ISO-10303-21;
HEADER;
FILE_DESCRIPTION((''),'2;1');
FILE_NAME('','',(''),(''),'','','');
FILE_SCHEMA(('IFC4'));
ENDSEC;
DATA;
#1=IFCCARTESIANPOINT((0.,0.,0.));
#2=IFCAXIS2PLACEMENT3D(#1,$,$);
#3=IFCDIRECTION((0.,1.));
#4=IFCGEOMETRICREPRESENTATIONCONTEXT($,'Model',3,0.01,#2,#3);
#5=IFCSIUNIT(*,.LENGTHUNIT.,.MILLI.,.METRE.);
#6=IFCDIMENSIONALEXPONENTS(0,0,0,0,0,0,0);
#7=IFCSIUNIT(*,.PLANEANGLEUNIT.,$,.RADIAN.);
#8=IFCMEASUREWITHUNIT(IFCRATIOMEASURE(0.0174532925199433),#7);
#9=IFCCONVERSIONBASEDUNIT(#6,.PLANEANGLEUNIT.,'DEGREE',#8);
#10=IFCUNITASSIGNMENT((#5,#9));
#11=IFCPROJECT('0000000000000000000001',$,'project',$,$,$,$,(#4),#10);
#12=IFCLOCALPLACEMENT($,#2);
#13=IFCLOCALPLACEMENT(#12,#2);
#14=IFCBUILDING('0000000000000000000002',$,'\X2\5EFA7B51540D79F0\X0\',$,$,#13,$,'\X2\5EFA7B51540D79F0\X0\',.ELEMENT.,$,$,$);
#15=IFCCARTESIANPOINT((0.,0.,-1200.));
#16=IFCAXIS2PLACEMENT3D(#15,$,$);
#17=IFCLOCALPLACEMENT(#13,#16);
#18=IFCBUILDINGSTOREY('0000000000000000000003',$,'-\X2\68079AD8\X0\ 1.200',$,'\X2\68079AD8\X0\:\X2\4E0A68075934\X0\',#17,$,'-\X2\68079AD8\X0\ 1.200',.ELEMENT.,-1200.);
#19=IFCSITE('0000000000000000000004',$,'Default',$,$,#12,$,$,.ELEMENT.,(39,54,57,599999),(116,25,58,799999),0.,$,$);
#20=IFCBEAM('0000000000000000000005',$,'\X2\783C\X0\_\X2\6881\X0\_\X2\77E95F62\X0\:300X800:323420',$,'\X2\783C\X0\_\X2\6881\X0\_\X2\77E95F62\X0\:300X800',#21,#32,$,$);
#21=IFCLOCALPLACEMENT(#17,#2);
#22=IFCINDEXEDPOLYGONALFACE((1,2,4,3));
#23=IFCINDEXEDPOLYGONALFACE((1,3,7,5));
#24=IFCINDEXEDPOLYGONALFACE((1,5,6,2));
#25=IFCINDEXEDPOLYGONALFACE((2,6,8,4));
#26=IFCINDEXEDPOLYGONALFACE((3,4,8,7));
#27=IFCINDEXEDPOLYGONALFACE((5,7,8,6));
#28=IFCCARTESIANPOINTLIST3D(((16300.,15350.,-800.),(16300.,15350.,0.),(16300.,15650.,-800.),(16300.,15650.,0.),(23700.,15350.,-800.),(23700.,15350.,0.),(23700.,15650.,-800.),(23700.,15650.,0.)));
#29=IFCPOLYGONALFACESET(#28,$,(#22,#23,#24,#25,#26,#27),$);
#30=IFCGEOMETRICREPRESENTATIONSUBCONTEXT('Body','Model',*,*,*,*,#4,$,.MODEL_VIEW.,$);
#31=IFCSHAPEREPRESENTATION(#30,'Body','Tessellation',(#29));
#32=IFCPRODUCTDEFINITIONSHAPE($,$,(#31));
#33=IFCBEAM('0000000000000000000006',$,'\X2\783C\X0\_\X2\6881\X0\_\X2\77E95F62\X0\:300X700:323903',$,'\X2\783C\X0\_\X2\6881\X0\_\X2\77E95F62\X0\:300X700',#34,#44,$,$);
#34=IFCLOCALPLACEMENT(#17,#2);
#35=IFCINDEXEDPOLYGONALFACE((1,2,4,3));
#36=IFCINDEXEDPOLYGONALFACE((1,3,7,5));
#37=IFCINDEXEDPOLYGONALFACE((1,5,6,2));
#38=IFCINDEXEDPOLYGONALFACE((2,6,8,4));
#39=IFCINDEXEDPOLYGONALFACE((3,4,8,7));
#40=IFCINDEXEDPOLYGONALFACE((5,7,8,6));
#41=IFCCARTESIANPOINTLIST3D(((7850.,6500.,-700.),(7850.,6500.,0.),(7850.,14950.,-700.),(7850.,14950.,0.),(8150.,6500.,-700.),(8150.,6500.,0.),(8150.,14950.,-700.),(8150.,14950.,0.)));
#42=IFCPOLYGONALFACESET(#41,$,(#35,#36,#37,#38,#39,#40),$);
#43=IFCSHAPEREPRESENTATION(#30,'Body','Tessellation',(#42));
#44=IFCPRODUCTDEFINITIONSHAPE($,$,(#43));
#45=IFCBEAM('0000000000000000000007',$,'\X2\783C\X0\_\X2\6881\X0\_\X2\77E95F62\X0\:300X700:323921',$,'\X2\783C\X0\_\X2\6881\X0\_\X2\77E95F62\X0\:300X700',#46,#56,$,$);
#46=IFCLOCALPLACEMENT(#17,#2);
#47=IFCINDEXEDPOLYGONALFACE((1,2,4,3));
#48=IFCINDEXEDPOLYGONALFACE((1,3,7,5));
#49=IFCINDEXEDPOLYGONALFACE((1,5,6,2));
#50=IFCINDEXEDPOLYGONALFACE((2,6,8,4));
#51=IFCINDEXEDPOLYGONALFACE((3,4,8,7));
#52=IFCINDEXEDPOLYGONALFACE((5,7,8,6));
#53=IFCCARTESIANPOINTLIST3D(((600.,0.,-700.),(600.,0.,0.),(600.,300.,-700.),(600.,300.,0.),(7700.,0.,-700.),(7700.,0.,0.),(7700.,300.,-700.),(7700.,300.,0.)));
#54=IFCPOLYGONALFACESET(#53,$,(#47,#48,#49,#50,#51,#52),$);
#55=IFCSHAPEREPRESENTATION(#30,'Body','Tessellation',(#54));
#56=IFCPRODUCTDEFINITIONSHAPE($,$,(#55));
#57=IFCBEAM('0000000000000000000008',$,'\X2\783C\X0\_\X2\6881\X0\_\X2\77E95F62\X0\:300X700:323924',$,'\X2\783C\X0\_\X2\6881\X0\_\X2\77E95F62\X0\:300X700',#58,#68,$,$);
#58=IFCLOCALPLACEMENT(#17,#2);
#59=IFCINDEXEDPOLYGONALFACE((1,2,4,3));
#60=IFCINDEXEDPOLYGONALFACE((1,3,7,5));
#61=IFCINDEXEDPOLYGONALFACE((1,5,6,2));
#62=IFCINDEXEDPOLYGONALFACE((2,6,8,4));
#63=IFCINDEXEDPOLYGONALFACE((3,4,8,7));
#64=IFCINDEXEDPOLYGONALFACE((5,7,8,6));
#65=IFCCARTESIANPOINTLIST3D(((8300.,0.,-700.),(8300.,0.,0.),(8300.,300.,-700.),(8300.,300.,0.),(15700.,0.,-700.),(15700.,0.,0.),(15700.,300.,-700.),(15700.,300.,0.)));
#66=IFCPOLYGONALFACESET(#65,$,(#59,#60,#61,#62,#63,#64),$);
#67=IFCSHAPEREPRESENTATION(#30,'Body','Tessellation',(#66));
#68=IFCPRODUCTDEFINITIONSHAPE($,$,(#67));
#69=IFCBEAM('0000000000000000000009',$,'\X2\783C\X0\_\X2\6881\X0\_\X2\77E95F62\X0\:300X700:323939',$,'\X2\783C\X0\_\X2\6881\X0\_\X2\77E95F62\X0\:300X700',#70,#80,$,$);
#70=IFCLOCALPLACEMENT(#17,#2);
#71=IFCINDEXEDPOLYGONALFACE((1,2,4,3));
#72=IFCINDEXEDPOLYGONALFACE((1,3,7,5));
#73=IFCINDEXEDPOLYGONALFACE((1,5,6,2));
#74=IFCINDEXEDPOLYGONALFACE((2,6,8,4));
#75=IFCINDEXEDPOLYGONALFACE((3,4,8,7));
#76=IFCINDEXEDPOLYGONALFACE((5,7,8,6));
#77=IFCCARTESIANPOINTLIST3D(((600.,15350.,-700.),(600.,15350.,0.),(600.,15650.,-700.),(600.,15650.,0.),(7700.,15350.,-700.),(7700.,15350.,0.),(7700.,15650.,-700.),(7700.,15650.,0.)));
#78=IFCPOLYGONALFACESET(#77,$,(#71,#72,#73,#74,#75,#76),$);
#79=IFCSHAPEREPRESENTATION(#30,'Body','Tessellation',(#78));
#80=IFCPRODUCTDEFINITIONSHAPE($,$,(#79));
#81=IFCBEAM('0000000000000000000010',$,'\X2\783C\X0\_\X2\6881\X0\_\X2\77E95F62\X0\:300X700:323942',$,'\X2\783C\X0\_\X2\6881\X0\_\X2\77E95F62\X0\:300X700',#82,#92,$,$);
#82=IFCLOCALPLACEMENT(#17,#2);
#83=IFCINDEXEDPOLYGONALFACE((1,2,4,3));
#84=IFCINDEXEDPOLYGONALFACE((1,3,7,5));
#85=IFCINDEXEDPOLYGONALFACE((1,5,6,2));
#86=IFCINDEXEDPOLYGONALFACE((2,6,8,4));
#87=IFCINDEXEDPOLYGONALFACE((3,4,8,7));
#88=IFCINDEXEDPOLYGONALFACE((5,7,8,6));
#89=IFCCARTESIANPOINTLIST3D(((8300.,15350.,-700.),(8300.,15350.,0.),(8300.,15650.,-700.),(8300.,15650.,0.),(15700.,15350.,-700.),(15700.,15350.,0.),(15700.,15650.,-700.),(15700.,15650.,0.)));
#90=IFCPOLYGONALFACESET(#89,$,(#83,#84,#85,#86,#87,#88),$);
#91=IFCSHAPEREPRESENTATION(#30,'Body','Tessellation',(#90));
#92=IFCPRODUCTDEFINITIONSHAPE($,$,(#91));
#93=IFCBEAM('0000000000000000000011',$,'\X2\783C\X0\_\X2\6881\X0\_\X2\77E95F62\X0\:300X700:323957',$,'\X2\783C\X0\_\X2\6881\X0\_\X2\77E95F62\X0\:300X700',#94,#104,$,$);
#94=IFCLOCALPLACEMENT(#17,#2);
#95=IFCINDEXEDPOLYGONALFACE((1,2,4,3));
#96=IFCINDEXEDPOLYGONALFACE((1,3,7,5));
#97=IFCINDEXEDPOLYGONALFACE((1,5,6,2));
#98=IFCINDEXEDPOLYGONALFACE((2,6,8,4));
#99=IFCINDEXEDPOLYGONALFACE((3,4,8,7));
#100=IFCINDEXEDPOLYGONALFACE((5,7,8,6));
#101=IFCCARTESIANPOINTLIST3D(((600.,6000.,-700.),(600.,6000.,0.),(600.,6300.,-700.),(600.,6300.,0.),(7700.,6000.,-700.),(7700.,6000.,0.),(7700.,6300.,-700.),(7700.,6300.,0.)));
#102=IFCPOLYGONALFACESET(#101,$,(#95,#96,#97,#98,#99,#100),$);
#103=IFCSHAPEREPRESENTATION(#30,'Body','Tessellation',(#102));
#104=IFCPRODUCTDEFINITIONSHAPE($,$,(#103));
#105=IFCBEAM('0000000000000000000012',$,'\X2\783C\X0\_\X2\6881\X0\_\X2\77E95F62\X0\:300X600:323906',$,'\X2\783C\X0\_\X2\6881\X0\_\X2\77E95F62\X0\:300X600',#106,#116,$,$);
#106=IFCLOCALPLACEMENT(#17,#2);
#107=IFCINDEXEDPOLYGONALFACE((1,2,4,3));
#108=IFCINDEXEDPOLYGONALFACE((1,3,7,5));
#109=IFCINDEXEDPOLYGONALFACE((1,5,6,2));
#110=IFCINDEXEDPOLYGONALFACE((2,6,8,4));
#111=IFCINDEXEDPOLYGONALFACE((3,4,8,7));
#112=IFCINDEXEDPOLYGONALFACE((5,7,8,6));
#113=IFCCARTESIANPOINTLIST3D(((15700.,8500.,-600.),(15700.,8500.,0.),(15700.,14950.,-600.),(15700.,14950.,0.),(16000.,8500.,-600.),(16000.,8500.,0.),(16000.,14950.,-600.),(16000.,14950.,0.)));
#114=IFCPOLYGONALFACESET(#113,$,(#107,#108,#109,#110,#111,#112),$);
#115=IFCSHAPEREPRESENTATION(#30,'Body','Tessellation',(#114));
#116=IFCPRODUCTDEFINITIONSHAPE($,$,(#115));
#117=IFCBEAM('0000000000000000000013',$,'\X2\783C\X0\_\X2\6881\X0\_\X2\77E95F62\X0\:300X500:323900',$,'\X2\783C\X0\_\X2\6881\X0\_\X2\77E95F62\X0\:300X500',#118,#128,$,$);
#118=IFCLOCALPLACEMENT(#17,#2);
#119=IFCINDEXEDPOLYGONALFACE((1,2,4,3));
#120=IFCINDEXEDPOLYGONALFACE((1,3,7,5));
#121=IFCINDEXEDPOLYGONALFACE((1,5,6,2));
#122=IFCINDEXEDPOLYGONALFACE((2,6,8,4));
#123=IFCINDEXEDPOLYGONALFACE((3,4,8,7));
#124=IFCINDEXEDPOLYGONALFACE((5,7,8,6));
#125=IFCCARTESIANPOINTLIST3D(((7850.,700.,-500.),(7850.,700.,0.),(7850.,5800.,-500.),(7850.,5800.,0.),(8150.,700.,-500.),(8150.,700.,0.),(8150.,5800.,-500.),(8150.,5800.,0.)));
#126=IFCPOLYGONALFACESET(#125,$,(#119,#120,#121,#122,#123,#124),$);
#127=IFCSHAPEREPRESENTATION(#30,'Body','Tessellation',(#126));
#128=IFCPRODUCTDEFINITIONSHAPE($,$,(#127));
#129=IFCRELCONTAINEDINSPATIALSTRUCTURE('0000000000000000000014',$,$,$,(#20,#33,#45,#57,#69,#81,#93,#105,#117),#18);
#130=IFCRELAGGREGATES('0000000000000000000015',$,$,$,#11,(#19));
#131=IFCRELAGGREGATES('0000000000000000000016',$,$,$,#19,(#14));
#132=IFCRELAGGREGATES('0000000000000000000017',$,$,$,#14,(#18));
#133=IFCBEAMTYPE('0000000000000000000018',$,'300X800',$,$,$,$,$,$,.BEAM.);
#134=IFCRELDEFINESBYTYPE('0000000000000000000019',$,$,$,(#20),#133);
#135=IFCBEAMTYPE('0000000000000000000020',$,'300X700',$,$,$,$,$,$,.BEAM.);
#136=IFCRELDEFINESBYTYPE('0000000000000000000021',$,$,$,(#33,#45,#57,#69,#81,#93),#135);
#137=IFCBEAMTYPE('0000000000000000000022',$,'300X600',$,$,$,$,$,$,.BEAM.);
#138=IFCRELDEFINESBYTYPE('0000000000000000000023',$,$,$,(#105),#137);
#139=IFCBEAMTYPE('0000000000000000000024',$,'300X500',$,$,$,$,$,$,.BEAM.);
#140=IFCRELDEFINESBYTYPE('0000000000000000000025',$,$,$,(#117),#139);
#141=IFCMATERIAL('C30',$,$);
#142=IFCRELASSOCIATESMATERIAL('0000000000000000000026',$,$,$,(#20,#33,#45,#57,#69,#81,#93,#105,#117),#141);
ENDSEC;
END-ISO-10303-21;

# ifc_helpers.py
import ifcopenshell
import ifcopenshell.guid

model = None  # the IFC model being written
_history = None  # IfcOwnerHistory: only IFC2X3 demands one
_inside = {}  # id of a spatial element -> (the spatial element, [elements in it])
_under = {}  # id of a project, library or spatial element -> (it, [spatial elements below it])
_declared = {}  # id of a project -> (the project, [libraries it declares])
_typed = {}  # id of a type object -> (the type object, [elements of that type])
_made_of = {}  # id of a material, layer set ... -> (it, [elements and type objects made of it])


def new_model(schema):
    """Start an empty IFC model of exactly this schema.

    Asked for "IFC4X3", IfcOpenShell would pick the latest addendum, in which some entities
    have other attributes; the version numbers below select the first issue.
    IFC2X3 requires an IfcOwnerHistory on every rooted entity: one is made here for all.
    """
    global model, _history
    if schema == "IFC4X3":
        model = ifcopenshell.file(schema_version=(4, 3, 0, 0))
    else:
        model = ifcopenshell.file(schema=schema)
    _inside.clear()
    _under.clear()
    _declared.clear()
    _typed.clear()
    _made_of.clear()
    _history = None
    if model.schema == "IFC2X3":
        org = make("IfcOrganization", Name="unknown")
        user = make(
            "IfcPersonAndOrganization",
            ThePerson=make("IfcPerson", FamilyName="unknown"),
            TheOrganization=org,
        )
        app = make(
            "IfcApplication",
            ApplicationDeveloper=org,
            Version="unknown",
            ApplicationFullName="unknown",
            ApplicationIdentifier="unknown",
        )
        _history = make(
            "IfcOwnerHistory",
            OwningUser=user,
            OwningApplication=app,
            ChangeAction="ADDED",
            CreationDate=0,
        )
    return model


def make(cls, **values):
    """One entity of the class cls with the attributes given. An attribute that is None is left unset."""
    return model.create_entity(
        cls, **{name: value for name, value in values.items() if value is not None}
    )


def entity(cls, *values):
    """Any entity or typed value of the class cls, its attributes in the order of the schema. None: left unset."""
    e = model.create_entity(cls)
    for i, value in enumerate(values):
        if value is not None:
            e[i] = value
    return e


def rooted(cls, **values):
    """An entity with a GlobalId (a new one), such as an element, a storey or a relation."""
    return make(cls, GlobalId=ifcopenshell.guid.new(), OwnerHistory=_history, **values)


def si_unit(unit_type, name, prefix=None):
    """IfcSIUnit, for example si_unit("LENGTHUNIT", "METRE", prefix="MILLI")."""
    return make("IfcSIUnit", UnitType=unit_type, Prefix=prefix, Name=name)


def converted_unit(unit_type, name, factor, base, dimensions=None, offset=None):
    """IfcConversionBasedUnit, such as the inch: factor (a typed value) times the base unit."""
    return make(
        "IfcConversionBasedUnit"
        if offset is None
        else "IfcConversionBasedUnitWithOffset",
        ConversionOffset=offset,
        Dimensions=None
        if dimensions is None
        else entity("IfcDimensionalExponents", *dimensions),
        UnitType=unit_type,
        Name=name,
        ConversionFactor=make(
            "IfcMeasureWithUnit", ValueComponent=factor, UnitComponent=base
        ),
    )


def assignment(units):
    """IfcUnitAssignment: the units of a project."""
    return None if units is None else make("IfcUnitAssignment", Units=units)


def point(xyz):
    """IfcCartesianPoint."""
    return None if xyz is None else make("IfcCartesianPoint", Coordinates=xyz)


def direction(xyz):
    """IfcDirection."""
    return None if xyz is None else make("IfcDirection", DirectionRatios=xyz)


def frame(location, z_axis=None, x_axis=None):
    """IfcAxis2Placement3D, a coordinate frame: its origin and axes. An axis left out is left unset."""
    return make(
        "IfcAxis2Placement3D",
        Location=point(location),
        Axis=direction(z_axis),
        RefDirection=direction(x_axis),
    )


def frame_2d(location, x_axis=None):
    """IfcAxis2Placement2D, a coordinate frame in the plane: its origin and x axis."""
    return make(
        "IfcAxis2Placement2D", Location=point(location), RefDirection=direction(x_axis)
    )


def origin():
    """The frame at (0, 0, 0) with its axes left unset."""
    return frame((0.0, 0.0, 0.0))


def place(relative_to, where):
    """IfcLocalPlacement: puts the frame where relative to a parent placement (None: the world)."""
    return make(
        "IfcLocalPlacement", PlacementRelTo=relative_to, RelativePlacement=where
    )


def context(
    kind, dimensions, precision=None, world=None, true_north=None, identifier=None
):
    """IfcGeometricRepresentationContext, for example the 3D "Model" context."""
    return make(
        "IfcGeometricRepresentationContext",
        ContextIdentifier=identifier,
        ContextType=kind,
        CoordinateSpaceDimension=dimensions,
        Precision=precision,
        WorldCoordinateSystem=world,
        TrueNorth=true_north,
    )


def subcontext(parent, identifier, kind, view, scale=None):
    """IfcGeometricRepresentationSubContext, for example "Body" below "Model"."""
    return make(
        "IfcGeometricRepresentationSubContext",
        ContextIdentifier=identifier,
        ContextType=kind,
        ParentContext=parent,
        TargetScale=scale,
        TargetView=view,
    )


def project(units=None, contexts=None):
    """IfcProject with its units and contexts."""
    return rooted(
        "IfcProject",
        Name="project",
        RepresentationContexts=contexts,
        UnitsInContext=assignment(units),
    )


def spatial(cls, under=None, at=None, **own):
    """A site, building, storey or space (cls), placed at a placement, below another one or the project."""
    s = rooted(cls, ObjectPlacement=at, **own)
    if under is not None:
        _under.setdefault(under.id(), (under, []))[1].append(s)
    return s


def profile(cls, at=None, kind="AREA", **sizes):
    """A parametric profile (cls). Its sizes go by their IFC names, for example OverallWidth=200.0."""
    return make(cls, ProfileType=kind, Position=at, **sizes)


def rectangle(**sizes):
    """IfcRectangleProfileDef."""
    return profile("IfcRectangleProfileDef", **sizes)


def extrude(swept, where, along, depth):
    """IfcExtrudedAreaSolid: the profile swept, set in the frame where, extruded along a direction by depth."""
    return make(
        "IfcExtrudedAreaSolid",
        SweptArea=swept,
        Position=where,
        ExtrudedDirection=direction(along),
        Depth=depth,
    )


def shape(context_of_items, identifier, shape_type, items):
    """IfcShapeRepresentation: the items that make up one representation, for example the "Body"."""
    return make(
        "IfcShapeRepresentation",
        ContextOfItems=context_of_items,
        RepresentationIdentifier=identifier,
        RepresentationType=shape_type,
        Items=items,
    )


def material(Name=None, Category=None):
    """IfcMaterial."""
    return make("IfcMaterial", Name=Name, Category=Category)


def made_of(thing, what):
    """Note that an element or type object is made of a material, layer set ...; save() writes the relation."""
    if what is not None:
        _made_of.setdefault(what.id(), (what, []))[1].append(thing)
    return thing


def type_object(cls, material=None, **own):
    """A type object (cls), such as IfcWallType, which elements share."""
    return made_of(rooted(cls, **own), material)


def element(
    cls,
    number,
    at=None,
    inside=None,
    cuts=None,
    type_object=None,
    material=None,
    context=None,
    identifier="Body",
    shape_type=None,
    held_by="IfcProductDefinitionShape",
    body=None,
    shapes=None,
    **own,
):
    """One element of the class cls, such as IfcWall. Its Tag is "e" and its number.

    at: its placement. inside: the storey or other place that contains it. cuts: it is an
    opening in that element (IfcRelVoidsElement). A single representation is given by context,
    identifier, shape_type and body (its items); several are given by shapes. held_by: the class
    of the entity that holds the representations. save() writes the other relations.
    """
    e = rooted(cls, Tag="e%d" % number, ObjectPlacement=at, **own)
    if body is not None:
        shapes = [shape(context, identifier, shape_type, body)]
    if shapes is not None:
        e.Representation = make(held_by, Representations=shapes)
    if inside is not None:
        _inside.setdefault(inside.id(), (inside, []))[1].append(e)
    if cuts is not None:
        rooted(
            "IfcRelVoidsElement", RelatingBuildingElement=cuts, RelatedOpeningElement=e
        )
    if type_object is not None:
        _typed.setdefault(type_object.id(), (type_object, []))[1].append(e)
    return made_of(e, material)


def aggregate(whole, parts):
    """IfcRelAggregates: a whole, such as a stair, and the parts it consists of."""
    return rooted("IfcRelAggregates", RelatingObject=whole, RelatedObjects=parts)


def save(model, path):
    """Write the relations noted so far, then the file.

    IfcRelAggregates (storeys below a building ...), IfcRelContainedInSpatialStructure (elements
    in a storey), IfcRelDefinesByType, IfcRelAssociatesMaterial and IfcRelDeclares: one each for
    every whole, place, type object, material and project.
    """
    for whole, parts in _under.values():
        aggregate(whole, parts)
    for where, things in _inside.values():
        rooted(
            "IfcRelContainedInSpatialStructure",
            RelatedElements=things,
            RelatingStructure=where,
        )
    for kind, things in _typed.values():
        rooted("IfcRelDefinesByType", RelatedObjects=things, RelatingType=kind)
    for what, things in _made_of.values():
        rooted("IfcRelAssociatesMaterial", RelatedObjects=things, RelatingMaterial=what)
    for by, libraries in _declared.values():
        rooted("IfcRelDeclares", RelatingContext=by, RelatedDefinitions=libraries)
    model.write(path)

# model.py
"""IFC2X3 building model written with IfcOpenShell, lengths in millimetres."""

from ifc_helpers import new_model, entity, si_unit, converted_unit, direction, frame, frame_2d, origin, place, context, subcontext, project, spatial, rectangle, extrude, material, type_object, element, save


model = new_model("IFC2X3")

# Units and contexts
model_context = context("Model", 3, precision=0.01, world=origin(), true_north=direction((0.0, 1.0)))
body_context = subcontext(model_context, "Body", "Model", "MODEL_VIEW")
ifc_project = project(units=[si_unit("LENGTHUNIT", "METRE", prefix="MILLI"), converted_unit("PLANEANGLEUNIT", "DEGREE", entity("IfcRatioMeasure", 0.0174532925199433), si_unit("PLANEANGLEUNIT", "RADIAN"), dimensions=[0, 0, 0, 0, 0, 0, 0])], contexts=[model_context])

# Site, building, storey
site_placement = place(None, origin())
site = spatial("IfcSite", under=ifc_project, at=site_placement, Name="Default", CompositionType="ELEMENT", RefLatitude=(39, 54, 57, 599999), RefLongitude=(116, 25, 58, 799999), RefElevation=0.0)
building_placement = place(site_placement, origin())
building = spatial("IfcBuilding", under=site, at=building_placement, Name="建筑名称", LongName="建筑名称", CompositionType="ELEMENT")
storey_placement = place(building_placement, frame((0.0, 0.0, -1200.0)))
storey = spatial("IfcBuildingStorey", under=building, at=storey_placement, Name="-标高 1.200", ObjectType="标高:上标头", LongName="-标高 1.200", CompositionType="ELEMENT", Elevation=-1200.0)

# Shared definitions
ifc_material_1 = material(Name="C30")

# Beams
beam_type_1 = type_object("IfcBeamType", Name="300X800", PredefinedType="BEAM")
beam_1_placement = place(storey_placement, frame((15850.0, 15650.0, 0.0)))
element("IfcBeam", 1, at=beam_1_placement, inside=storey, type_object=beam_type_1, material=ifc_material_1, Name="砼_梁_矩形:300X800:323420", ObjectType="砼_梁_矩形:300X800", context=body_context, shape_type="SweptSolid", body=[
    extrude(rectangle(XDim=800.0, YDim=300.0, at=frame_2d((0.0, 0.0), x_axis=(1.0, 0.0))), frame((450.0, -150.0, -400.0), z_axis=(1.0, 0.0, 0.0), x_axis=(0.0, 0.0, -1.0)), (0.0, 0.0, 1.0), 7400.0),
])
beam_type_2 = type_object("IfcBeamType", Name="300X700", PredefinedType="BEAM")
beam_2_placement = place(storey_placement, frame((8000.0, 6150.0, 0.0), z_axis=(0.0, 0.0, 1.0), x_axis=(0.0, 1.0, 0.0)))
element("IfcBeam", 2, at=beam_2_placement, inside=storey, type_object=beam_type_2, material=ifc_material_1, Name="砼_梁_矩形:300X700:323903", ObjectType="砼_梁_矩形:300X700", context=body_context, shape_type="SweptSolid", body=[
    extrude(rectangle(XDim=700.0, YDim=300.0, at=frame_2d((0.0, 0.0), x_axis=(1.0, 0.0))), frame((350.0, 0.0, -350.0), z_axis=(1.0, 0.0, 0.0), x_axis=(0.0, 0.0, -1.0)), (0.0, 0.0, 1.0), 8450.0),
])
beam_3_placement = place(storey_placement, frame((150.0, 0.0, 0.0)))
element("IfcBeam", 3, at=beam_3_placement, inside=storey, type_object=beam_type_2, material=ifc_material_1, Name="砼_梁_矩形:300X700:323921", ObjectType="砼_梁_矩形:300X700", context=body_context, shape_type="SweptSolid", body=[
    extrude(rectangle(XDim=700.0, YDim=300.0, at=frame_2d((0.0, 0.0), x_axis=(1.0, 0.0))), frame((450.0, 150.0, -350.0), z_axis=(1.0, 0.0, 0.0), x_axis=(0.0, 0.0, -1.0)), (0.0, 0.0, 1.0), 7100.0),
])
beam_4_placement = place(storey_placement, frame((8000.0, 0.0, 0.0)))
element("IfcBeam", 4, at=beam_4_placement, inside=storey, type_object=beam_type_2, material=ifc_material_1, Name="砼_梁_矩形:300X700:323924", ObjectType="砼_梁_矩形:300X700", context=body_context, shape_type="SweptSolid", body=[
    extrude(rectangle(XDim=700.0, YDim=300.0, at=frame_2d((0.0, 0.0), x_axis=(1.0, 0.0))), frame((300.0, 150.0, -350.0), z_axis=(1.0, 0.0, 0.0), x_axis=(0.0, 0.0, -1.0)), (0.0, 0.0, 1.0), 7400.0),
])
beam_5_placement = place(storey_placement, frame((150.0, 15650.0, 0.0)))
element("IfcBeam", 5, at=beam_5_placement, inside=storey, type_object=beam_type_2, material=ifc_material_1, Name="砼_梁_矩形:300X700:323939", ObjectType="砼_梁_矩形:300X700", context=body_context, shape_type="SweptSolid", body=[
    extrude(rectangle(XDim=700.0, YDim=300.0, at=frame_2d((0.0, 0.0), x_axis=(1.0, 0.0))), frame((450.0, -150.0, -350.0), z_axis=(1.0, 0.0, 0.0), x_axis=(0.0, 0.0, -1.0)), (0.0, 0.0, 1.0), 7100.0),
])
beam_6_placement = place(storey_placement, frame((8000.0, 15650.0, 0.0)))
element("IfcBeam", 6, at=beam_6_placement, inside=storey, type_object=beam_type_2, material=ifc_material_1, Name="砼_梁_矩形:300X700:323942", ObjectType="砼_梁_矩形:300X700", context=body_context, shape_type="SweptSolid", body=[
    extrude(rectangle(XDim=700.0, YDim=300.0, at=frame_2d((0.0, 0.0), x_axis=(1.0, 0.0))), frame((300.0, -150.0, -350.0), z_axis=(1.0, 0.0, 0.0), x_axis=(0.0, 0.0, -1.0)), (0.0, 0.0, 1.0), 7400.0),
])
beam_7_placement = place(storey_placement, frame((150.0, 6150.0, 0.0)))
element("IfcBeam", 7, at=beam_7_placement, inside=storey, type_object=beam_type_2, material=ifc_material_1, Name="砼_梁_矩形:300X700:323957", ObjectType="砼_梁_矩形:300X700", context=body_context, shape_type="SweptSolid", body=[
    extrude(rectangle(XDim=700.0, YDim=300.0, at=frame_2d((0.0, 0.0), x_axis=(1.0, 0.0))), frame((450.0, 0.0, -350.0), z_axis=(1.0, 0.0, 0.0), x_axis=(0.0, 0.0, -1.0)), (0.0, 0.0, 1.0), 7100.0),
])
beam_type_3 = type_object("IfcBeamType", Name="300X600", PredefinedType="BEAM")
beam_8_placement = place(storey_placement, frame((16000.0, 8150.0, 0.0), z_axis=(0.0, 0.0, 1.0), x_axis=(0.0, 1.0, 0.0)))
element("IfcBeam", 8, at=beam_8_placement, inside=storey, type_object=beam_type_3, material=ifc_material_1, Name="砼_梁_矩形:300X600:323906", ObjectType="砼_梁_矩形:300X600", context=body_context, shape_type="SweptSolid", body=[
    extrude(rectangle(XDim=600.0, YDim=300.0, at=frame_2d((0.0, 0.0), x_axis=(1.0, 0.0))), frame((350.0, 150.0, -300.0), z_axis=(1.0, 0.0, 0.0), x_axis=(0.0, 0.0, -1.0)), (0.0, 0.0, 1.0), 6450.0),
])
beam_type_4 = type_object("IfcBeamType", Name="300X500", PredefinedType="BEAM")
beam_9_placement = place(storey_placement, frame((8000.0, 150.0, 0.0), z_axis=(0.0, 0.0, 1.0), x_axis=(0.0, 1.0, 0.0)))
element("IfcBeam", 9, at=beam_9_placement, inside=storey, type_object=beam_type_4, material=ifc_material_1, Name="砼_梁_矩形:300X500:323900", ObjectType="砼_梁_矩形:300X500", context=body_context, shape_type="SweptSolid", body=[
    extrude(rectangle(XDim=500.0, YDim=300.0, at=frame_2d((0.0, 0.0), x_axis=(1.0, 0.0))), frame((550.0, 0.0, -250.0), z_axis=(1.0, 0.0, 0.0), x_axis=(0.0, 0.0, -1.0)), (0.0, 0.0, 1.0), 5100.0),
])

save(model, "model.ifc")
